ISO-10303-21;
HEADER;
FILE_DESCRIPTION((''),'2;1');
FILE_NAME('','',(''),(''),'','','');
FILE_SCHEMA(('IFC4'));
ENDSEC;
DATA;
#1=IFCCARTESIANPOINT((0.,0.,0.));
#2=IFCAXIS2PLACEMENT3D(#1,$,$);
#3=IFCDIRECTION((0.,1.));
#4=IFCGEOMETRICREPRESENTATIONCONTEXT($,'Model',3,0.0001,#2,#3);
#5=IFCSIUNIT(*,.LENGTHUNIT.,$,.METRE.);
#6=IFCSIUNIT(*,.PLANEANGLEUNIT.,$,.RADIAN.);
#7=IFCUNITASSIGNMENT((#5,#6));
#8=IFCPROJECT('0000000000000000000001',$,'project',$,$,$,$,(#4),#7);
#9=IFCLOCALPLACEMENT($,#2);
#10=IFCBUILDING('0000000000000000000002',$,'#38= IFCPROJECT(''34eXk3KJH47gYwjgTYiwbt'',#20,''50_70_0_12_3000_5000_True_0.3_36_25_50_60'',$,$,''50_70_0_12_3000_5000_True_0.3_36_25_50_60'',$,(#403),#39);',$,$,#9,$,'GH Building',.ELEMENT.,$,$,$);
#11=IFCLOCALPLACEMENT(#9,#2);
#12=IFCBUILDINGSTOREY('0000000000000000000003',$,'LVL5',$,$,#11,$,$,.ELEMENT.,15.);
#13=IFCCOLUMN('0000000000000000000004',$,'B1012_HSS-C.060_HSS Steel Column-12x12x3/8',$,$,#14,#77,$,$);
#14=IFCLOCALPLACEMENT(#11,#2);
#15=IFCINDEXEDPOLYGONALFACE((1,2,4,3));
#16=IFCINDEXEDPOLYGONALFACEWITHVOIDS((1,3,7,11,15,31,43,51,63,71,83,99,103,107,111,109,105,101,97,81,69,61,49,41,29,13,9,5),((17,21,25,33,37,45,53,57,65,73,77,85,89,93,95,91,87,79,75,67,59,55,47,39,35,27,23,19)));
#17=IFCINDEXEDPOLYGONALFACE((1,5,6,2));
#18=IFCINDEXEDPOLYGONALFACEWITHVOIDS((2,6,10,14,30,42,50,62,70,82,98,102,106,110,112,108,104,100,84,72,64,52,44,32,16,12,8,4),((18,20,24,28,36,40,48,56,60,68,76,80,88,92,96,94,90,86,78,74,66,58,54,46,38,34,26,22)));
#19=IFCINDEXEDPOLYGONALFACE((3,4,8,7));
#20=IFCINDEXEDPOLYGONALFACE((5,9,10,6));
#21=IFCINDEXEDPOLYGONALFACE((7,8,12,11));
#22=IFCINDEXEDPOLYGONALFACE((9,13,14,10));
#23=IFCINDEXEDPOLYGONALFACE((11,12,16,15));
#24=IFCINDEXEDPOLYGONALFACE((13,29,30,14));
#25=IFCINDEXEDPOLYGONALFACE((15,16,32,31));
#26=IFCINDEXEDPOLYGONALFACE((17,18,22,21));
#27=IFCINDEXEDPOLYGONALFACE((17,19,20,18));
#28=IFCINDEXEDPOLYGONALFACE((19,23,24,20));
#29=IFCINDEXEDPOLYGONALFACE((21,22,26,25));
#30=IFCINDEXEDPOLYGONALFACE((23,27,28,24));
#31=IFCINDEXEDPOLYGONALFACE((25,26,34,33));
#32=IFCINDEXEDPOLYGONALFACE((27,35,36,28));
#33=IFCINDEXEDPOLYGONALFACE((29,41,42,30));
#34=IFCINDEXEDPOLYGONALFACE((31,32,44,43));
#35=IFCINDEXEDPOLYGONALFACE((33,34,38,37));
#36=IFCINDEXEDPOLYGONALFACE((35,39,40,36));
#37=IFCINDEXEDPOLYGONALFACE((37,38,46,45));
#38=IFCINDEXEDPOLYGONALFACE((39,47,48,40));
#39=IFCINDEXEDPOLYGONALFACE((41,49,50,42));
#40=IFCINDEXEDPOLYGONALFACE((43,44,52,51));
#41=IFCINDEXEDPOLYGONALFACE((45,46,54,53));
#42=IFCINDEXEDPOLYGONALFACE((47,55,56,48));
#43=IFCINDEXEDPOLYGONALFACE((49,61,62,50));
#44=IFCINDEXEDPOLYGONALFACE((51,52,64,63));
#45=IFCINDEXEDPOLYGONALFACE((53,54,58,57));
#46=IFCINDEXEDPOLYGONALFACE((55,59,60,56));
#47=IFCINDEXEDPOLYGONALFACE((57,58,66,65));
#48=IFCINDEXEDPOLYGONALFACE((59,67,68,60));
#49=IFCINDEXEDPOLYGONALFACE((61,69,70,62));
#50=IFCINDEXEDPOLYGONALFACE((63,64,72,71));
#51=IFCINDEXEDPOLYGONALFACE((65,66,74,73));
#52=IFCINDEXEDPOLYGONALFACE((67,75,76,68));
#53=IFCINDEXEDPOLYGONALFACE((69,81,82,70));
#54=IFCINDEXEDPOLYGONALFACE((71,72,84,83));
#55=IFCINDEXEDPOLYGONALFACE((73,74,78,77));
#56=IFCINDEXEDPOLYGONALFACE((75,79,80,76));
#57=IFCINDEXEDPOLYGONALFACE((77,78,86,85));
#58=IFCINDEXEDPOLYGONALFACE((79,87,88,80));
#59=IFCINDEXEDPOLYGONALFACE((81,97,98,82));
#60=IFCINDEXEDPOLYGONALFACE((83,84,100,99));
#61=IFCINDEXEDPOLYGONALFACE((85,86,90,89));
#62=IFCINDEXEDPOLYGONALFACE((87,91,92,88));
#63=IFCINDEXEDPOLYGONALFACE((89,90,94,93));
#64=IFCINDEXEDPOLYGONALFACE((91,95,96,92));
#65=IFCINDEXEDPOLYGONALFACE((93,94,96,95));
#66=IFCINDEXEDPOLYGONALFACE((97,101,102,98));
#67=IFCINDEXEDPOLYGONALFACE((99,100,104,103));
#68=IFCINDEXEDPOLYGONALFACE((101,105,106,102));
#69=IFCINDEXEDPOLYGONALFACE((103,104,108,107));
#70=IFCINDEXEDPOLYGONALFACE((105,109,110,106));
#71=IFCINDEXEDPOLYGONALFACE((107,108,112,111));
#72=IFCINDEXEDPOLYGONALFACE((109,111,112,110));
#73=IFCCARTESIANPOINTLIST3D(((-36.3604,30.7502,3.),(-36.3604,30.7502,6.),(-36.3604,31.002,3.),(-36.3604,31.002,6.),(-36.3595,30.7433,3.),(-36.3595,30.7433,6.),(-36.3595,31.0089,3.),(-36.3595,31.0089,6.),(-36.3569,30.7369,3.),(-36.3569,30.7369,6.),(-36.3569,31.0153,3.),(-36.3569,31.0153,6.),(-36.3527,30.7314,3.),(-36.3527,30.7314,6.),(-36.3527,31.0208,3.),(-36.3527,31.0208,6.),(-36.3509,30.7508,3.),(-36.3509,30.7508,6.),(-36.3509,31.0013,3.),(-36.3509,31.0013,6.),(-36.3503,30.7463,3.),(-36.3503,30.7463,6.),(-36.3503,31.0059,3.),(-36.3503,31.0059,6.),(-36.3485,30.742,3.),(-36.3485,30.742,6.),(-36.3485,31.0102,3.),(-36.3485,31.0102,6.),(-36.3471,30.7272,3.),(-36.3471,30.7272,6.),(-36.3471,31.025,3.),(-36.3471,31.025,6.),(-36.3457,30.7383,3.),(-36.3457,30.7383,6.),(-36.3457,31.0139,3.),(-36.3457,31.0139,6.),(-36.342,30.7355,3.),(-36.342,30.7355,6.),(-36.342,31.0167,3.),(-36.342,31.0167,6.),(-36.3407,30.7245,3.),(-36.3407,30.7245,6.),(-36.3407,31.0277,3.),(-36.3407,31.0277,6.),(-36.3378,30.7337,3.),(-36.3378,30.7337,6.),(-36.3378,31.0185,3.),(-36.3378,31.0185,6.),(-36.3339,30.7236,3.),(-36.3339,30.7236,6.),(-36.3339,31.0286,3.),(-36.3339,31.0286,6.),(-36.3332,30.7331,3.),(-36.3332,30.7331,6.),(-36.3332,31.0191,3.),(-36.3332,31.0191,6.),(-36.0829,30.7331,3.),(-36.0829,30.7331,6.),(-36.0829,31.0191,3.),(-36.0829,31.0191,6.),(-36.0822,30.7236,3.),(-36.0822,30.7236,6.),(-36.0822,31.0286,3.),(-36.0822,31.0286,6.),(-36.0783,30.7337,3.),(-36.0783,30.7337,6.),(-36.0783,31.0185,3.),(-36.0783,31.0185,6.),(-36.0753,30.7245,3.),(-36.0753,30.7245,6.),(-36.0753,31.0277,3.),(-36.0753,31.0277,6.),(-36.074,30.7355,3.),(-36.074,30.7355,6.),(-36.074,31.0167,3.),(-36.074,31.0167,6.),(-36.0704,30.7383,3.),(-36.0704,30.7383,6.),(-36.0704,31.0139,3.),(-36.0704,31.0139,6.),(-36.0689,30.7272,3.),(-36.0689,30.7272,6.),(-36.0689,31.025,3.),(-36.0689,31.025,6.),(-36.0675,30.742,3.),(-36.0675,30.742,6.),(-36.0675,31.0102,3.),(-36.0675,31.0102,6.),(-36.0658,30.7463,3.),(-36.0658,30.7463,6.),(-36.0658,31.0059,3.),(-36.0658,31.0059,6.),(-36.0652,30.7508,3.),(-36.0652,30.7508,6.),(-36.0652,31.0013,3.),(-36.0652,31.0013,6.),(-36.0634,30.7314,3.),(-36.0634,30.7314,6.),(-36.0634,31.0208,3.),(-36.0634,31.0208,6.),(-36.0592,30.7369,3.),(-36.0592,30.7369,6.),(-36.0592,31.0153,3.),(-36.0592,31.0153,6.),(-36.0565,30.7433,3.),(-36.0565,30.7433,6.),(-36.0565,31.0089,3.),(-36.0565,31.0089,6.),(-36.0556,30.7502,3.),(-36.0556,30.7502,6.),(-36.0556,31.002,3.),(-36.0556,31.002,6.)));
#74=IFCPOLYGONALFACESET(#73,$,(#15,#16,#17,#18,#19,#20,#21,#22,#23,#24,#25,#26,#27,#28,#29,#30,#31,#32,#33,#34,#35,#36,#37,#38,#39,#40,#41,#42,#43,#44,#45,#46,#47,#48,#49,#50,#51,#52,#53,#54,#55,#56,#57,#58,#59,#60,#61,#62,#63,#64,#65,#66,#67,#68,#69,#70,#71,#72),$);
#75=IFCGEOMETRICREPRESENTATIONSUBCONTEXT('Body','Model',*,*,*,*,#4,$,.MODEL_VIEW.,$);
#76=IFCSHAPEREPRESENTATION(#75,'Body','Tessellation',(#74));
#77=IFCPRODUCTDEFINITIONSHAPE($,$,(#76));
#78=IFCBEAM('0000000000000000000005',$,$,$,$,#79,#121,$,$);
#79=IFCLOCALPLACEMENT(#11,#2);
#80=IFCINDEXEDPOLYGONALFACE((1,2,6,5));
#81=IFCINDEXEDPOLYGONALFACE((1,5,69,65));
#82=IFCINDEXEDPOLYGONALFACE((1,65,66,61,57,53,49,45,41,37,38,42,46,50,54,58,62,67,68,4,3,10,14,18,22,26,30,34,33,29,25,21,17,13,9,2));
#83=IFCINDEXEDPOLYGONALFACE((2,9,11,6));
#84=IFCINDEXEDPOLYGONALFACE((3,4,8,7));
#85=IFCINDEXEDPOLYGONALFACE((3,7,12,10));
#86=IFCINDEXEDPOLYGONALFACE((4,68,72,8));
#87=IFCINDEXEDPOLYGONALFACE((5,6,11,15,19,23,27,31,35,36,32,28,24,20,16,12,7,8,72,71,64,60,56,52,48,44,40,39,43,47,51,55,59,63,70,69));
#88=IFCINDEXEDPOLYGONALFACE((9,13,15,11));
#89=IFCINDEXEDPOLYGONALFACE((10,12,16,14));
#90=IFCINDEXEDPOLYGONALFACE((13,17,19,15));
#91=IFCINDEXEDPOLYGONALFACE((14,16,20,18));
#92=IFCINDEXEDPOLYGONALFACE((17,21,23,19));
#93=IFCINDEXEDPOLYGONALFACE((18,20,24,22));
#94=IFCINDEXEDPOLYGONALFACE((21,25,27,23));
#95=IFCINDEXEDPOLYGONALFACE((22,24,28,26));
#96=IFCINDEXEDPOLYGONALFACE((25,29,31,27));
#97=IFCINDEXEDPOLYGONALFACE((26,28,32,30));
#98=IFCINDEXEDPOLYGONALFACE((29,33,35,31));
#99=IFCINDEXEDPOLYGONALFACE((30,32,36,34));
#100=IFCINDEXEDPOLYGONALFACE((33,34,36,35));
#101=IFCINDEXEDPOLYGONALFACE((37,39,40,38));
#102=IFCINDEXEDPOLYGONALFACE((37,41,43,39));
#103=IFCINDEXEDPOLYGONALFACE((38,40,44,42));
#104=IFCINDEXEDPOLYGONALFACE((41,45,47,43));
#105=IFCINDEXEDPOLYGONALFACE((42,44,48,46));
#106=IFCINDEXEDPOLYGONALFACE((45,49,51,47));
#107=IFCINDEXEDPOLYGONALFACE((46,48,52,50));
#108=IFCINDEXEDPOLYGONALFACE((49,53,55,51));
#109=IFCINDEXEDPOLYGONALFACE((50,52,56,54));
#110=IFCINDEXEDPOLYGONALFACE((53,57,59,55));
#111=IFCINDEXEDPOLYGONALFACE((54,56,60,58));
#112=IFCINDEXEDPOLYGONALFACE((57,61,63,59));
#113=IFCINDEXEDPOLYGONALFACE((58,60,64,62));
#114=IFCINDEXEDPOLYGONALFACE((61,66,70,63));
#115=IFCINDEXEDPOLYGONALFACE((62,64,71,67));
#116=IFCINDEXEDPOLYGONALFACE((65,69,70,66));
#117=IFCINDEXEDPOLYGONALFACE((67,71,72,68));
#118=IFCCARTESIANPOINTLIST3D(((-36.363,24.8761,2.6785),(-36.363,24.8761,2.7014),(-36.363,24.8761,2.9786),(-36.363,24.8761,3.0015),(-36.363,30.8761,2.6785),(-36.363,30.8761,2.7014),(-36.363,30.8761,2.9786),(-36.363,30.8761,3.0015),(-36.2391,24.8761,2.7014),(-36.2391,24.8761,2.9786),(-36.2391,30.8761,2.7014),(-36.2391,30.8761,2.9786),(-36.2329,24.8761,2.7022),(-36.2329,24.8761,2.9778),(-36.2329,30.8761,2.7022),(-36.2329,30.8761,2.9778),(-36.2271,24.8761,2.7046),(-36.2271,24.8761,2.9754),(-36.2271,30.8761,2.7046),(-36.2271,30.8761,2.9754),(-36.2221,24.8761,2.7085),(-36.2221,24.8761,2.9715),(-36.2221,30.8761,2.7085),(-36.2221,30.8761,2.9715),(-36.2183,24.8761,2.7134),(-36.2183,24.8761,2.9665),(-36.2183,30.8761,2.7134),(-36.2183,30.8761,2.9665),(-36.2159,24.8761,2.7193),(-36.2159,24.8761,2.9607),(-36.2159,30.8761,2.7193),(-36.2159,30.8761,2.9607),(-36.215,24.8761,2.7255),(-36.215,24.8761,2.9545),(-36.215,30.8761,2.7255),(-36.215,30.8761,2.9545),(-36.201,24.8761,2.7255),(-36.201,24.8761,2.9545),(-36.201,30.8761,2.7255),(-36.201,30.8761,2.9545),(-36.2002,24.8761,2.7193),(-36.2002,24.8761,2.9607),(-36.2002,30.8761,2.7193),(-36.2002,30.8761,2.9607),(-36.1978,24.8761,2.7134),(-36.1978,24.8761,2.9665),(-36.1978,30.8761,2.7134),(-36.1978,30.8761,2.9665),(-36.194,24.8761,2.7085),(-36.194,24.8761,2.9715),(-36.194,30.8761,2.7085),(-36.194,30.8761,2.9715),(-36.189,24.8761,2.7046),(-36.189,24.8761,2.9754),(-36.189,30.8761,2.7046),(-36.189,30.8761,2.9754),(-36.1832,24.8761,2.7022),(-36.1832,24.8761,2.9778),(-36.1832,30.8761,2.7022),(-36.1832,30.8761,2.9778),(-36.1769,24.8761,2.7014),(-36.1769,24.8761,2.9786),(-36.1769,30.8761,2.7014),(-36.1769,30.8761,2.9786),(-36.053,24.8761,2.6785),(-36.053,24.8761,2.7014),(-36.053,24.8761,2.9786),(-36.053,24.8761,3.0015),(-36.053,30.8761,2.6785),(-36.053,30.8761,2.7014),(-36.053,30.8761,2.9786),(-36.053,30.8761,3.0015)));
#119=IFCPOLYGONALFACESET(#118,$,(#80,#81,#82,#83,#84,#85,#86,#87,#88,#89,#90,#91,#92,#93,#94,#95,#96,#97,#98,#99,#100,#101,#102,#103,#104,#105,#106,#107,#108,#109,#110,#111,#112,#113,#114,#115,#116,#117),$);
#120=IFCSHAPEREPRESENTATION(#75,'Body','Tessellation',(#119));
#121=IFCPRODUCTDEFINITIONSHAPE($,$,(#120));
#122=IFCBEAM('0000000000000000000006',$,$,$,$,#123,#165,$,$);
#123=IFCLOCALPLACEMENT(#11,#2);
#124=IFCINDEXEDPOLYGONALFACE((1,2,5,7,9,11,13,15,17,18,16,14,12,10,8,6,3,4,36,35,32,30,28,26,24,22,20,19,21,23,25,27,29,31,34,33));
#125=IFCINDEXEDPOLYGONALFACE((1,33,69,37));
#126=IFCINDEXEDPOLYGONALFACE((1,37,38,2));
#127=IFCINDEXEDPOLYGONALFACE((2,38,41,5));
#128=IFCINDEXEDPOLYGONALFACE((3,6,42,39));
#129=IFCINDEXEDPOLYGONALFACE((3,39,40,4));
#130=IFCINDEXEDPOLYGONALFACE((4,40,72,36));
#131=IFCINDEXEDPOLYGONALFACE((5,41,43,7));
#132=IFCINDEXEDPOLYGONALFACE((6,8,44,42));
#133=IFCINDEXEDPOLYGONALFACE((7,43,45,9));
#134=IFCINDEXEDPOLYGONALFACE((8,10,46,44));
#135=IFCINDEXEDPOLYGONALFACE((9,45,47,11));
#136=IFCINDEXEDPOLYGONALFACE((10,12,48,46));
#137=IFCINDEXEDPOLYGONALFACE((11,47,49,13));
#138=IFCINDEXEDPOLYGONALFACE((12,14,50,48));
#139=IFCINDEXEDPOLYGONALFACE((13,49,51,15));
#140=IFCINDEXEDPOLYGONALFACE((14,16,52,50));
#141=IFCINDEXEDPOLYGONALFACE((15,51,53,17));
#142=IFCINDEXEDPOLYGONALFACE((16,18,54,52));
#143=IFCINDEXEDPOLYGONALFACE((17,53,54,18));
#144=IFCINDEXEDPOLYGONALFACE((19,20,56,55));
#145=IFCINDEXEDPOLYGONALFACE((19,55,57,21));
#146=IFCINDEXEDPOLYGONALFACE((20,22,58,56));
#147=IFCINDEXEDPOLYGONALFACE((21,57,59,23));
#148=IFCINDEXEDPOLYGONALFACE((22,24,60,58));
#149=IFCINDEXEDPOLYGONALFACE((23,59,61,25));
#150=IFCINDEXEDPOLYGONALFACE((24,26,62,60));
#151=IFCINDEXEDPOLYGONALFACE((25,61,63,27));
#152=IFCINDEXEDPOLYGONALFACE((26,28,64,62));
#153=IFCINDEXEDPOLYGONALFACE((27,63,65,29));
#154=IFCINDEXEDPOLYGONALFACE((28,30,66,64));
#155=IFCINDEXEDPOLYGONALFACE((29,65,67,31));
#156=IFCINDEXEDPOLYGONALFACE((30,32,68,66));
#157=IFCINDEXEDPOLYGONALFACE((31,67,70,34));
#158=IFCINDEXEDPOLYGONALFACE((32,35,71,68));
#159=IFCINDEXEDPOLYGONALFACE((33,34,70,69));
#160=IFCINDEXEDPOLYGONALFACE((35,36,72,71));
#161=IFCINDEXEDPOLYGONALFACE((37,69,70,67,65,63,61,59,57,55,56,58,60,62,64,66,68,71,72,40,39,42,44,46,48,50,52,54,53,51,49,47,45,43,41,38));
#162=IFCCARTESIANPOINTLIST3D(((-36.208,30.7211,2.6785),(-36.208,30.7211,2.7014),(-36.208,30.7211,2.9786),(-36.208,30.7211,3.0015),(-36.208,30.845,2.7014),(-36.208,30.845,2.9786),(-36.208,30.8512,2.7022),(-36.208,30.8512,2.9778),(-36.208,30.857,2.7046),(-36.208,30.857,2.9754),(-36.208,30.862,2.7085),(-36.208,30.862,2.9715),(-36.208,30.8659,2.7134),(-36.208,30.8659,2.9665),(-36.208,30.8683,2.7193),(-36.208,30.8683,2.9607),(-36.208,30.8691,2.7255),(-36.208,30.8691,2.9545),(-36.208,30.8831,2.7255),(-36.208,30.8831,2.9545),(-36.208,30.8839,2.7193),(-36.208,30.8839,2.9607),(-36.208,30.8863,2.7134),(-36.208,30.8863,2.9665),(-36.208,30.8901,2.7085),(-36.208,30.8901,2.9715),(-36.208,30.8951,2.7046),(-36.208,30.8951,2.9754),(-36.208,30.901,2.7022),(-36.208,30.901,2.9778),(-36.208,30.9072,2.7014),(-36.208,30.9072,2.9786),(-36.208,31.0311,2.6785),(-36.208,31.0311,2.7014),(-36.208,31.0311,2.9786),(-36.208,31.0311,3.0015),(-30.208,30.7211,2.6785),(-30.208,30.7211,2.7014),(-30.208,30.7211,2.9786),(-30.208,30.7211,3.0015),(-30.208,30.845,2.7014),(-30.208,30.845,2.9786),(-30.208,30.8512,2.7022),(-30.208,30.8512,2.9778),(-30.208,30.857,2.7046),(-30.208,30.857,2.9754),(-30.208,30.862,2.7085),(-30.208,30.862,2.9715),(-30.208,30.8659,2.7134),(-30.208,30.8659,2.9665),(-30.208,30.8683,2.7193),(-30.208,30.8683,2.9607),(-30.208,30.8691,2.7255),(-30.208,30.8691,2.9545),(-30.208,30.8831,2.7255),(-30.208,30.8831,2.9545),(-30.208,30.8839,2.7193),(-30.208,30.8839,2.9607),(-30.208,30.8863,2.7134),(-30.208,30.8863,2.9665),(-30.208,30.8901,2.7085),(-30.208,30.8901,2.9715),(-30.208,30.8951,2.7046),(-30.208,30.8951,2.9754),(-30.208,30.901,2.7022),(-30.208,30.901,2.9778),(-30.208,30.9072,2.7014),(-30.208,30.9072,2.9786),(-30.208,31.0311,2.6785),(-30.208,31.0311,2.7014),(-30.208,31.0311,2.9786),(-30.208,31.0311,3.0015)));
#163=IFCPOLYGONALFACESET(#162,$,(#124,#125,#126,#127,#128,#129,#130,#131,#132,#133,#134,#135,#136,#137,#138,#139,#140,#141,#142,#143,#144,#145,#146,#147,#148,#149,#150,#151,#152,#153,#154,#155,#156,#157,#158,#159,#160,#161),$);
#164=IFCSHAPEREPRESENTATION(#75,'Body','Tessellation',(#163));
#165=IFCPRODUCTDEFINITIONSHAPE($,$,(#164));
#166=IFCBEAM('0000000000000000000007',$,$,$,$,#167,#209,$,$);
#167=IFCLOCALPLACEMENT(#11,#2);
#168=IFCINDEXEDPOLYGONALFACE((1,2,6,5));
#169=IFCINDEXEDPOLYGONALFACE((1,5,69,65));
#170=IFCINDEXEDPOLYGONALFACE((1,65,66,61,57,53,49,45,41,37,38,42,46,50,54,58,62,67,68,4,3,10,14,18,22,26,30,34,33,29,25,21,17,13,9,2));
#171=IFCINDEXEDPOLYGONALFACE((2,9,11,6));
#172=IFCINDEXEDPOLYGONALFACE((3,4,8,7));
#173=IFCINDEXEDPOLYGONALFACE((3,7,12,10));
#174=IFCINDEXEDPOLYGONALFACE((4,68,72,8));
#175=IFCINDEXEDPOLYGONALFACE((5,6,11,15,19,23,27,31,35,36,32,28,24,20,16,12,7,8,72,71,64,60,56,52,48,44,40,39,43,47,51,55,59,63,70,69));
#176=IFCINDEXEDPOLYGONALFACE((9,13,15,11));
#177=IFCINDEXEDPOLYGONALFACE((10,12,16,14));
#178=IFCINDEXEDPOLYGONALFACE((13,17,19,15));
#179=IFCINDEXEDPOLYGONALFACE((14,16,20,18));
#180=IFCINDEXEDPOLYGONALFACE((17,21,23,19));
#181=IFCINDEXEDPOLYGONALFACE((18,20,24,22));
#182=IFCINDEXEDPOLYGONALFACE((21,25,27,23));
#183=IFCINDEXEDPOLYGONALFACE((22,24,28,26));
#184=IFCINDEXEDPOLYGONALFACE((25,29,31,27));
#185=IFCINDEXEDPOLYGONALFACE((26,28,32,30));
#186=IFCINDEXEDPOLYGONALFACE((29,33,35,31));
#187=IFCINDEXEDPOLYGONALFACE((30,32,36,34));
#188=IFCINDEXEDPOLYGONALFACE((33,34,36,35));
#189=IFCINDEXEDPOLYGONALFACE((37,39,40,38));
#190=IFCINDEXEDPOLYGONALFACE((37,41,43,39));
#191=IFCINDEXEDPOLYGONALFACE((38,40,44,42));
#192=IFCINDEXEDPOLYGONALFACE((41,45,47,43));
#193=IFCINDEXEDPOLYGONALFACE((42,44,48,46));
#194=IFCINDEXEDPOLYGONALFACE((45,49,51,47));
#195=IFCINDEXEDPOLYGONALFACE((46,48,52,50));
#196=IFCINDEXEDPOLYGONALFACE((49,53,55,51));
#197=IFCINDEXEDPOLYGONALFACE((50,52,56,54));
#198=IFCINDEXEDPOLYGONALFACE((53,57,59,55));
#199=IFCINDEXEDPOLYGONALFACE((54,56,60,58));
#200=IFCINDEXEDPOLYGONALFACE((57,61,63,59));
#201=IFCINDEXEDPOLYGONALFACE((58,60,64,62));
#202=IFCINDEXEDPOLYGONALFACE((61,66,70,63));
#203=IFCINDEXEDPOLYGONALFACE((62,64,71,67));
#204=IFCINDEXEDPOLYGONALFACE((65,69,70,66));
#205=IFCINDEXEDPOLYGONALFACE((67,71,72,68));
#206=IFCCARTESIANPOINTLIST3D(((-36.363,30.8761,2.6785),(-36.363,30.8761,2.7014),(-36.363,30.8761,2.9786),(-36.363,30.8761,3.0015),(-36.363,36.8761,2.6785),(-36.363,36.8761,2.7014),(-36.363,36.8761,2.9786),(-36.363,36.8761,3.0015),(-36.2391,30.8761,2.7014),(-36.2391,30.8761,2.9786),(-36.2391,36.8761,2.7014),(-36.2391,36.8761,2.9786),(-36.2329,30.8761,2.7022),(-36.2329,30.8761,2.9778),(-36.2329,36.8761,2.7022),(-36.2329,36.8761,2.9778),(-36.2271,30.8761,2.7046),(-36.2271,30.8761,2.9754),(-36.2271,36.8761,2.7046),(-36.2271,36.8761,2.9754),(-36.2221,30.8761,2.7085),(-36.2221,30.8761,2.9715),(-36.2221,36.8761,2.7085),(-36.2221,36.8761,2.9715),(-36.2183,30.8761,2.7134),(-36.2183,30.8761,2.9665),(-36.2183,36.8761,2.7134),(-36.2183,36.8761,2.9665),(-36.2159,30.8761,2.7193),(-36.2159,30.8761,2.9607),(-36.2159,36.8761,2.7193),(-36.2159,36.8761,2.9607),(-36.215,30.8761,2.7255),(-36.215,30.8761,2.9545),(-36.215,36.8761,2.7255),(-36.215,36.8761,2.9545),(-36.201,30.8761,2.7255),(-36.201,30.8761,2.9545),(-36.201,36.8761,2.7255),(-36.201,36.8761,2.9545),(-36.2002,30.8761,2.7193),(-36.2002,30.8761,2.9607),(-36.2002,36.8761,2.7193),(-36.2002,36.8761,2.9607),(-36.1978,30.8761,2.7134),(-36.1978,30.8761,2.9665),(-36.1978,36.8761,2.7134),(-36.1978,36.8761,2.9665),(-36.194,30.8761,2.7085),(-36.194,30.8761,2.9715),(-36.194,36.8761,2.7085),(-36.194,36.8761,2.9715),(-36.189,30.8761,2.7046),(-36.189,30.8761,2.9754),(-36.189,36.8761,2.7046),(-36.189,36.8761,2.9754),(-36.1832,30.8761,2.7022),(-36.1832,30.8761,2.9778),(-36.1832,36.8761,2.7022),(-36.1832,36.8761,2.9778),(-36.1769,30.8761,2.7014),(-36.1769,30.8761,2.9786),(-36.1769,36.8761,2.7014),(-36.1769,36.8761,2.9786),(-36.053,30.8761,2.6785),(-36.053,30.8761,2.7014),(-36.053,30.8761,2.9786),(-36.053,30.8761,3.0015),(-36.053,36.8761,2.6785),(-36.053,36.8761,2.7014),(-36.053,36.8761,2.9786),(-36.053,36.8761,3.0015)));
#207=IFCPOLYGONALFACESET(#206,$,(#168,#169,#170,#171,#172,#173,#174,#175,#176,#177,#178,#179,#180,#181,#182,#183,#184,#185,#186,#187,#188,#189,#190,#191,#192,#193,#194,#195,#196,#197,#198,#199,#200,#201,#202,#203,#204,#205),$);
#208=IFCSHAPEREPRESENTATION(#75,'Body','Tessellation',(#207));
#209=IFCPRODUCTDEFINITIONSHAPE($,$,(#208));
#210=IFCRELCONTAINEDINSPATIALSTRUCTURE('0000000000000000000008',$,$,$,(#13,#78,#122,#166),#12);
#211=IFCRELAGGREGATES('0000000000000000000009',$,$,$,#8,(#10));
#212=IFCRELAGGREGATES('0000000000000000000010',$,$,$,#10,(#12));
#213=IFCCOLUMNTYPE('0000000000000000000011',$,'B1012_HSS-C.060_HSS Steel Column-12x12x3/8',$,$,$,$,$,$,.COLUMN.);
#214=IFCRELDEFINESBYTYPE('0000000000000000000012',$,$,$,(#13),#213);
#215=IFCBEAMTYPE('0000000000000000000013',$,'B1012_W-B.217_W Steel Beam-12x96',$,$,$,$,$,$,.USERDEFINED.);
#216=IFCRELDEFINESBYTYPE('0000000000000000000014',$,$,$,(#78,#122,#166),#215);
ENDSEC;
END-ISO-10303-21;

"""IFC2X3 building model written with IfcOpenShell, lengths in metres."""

from ifc_helpers import new_model, si_unit, direction, frame, origin, origin_2d, place, context, subcontext, project, spatial, hollow_rectangle, i_section, extrude, type_object, element, save


model = new_model("IFC2X3")

# Units and contexts
model_context = context("Model", 3, precision=0.0001, world=origin(), true_north=direction((0.0, 1.0)))
body_context = subcontext(model_context, "Body", "Model", "MODEL_VIEW")
ifc_project = project(units=[si_unit("LENGTHUNIT", "METRE"), si_unit("PLANEANGLEUNIT", "RADIAN")], contexts=[model_context])

# Building, storey
building_placement = place(None, origin())
building = spatial("IfcBuilding", under=ifc_project, at=building_placement, Name="#38= IFCPROJECT('34eXk3KJH47gYwjgTYiwbt',#20,'50_70_0_12_3000_5000_True_0.3_36_25_50_60',$,$,'50_70_0_12_3000_5000_True_0.3_36_25_50_60',$,(#403),#39);", LongName="GH Building", CompositionType="ELEMENT")
storey_placement = place(building_placement, origin())
storey = spatial("IfcBuildingStorey", under=building, at=storey_placement, Name="LVL5", CompositionType="ELEMENT", Elevation=15.0)

# Column
column_type = type_object("IfcColumnType", Name="B1012_HSS-C.060_HSS Steel Column-12x12x3/8", PredefinedType="COLUMN")
for number, where, z_axis, x_axis, name in (
    (1, (-36.208, 30.8761, 6.0), (0.0, 0.0, -1.0), (-1.0, 0.0, 0.0), "B1012_HSS-C.060_HSS Steel Column-12x12x3/8"),
):
    element("IfcColumn", number, at=place(storey_placement, frame(where, z_axis=z_axis, x_axis=x_axis)), inside=storey, type_object=column_type, Name=name, context=body_context, shape_type="SweptSolid", body=[
        extrude(hollow_rectangle(XDim=0.3048, YDim=0.305, WallThickness=0.0095, InnerFilletRadius=0.0177, OuterFilletRadius=0.0266, at=origin_2d()), origin(), (0.0, 0.0, 1.0), 3.0),
    ])

# Beams
beam_type = type_object("IfcBeamType", Name="B1012_W-B.217_W Steel Beam-12x96", PredefinedType="USERDEFINED")
for number, where, z_axis, x_axis in (
    (2, (-36.208, 24.8761, 2.84), (0.0, 1.0, 0.0), (-1.0, 0.0, 0.0)),
    (3, (-36.208, 30.8761, 2.84), (1.0, 0.0, 0.0), (0.0, 1.0, 0.0)),
    (4, (-36.208, 30.8761, 2.84), (0.0, 1.0, 0.0), (-1.0, 0.0, 0.0)),
):
    element("IfcBeam", number, at=place(storey_placement, frame(where, z_axis=z_axis, x_axis=x_axis)), inside=storey, type_object=beam_type, context=body_context, shape_type="SweptSolid", body=[
        extrude(i_section(OverallWidth=0.31, OverallDepth=0.323, WebThickness=0.014, FlangeThickness=0.0229, FilletRadius=0.0241, at=origin_2d()), origin(), (0.0, 0.0, 1.0), 6.0),
    ])

save(model, "model.ifc")
